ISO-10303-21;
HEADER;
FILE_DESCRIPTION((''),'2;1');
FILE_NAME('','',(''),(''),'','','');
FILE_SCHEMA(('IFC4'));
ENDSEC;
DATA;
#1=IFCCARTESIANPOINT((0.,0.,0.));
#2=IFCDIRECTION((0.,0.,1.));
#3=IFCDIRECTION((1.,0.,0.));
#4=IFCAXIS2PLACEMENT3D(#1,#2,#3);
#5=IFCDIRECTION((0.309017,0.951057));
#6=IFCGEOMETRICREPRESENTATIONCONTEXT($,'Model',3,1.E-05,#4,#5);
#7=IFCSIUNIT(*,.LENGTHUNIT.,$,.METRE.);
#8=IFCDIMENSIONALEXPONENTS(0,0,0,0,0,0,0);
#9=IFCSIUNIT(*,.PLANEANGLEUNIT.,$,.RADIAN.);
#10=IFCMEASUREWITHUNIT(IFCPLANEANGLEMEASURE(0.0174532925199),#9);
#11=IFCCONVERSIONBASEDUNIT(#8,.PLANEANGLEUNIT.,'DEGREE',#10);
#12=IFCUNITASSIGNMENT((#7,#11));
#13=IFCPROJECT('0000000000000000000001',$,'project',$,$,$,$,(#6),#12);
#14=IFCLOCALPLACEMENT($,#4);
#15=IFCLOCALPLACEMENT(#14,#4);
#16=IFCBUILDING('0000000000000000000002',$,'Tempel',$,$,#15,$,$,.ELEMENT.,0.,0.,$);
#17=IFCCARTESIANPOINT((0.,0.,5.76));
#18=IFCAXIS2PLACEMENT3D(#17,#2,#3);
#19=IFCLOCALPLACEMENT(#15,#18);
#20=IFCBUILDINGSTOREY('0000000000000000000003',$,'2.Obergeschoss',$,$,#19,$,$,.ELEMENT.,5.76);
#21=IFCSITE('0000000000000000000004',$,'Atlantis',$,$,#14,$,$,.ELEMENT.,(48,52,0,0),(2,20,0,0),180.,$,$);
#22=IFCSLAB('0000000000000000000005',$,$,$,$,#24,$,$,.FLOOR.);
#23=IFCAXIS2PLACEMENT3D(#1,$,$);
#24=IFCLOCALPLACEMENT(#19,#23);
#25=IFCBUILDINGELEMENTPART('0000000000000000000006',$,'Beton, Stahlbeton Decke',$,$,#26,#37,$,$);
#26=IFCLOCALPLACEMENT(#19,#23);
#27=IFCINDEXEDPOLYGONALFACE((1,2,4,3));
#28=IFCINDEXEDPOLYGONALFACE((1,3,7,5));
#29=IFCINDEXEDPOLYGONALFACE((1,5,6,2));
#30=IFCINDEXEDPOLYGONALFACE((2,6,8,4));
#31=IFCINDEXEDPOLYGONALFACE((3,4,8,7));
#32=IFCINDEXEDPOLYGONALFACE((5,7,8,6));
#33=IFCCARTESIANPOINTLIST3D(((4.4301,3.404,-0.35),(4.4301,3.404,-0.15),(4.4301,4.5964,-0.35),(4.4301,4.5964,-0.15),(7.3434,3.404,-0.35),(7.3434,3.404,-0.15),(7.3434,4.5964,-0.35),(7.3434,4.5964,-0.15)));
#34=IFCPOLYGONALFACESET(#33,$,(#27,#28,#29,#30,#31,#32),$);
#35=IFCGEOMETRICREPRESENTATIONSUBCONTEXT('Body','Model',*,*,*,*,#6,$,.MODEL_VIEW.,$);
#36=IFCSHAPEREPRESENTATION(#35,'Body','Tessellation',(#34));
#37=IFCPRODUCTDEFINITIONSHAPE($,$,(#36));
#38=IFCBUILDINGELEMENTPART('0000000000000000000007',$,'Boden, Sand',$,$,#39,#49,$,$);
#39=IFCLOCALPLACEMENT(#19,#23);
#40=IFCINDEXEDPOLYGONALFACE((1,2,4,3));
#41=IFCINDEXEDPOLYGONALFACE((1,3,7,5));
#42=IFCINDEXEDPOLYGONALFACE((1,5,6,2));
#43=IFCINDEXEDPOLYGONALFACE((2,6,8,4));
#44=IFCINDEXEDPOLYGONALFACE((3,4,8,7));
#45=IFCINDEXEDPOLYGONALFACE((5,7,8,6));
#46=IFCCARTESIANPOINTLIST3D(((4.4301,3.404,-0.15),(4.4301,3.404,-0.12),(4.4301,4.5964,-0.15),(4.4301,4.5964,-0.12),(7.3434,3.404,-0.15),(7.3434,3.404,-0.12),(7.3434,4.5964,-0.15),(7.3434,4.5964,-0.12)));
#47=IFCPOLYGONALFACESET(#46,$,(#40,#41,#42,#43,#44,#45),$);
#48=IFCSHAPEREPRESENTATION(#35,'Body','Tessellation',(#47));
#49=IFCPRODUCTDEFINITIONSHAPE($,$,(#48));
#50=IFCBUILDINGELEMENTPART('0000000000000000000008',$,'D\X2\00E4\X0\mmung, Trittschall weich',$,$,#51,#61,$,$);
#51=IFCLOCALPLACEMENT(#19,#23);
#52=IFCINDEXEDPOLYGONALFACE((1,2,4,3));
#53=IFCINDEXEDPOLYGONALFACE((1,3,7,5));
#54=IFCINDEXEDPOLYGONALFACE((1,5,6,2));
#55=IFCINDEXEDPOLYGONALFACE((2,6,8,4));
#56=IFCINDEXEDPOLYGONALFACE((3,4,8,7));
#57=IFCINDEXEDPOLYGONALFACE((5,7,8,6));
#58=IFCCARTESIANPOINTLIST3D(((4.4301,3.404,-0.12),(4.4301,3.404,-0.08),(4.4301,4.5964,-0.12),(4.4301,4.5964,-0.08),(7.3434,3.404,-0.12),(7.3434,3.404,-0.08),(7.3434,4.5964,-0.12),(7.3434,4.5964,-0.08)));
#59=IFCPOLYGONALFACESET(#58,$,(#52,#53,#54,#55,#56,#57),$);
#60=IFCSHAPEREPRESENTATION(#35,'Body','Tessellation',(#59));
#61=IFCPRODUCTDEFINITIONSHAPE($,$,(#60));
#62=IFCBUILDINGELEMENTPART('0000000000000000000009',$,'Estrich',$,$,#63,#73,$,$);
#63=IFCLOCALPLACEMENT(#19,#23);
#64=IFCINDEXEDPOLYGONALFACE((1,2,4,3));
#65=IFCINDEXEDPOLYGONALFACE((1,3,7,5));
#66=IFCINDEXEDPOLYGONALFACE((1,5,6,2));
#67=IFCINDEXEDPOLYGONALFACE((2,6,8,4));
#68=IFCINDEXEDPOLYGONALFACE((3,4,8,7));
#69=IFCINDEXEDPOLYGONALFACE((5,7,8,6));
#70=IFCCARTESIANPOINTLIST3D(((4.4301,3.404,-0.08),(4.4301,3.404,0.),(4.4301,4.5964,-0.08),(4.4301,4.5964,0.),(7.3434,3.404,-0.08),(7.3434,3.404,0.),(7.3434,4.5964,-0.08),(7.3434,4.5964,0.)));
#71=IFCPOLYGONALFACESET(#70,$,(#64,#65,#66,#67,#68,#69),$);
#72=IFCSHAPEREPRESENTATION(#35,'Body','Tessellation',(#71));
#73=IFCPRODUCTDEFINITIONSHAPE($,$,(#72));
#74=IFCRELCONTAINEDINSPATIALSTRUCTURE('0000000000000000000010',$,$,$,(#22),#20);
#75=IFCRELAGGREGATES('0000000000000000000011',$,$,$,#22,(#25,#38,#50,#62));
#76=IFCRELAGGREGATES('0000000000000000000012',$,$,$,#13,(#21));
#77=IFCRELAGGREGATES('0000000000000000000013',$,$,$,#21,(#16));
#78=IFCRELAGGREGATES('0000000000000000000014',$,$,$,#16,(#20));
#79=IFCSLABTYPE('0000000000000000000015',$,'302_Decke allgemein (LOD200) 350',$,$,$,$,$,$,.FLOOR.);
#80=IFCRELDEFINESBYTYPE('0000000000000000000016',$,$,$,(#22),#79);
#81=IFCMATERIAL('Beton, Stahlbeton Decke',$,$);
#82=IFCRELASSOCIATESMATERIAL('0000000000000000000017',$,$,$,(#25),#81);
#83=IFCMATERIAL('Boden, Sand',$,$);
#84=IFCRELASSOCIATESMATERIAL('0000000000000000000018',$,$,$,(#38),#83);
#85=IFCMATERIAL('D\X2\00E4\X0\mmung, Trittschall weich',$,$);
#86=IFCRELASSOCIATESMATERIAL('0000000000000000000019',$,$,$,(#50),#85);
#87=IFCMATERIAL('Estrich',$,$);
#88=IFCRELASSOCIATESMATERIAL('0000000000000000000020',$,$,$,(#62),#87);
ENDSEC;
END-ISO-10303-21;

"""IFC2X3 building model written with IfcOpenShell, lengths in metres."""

from ifc_helpers import new_model, entity, si_unit, converted_unit, direction, frame, origin_with_axes, place, context, subcontext, project, spatial, polyline, outline, extrude, material, type_object, element, aggregate, save


model = new_model("IFC2X3")

# Units and contexts
model_context = context("Model", 3, precision=1e-05, world=origin_with_axes(), true_north=direction((0.309017, 0.951057)))
body_context = subcontext(model_context, "Body", "Model", "MODEL_VIEW")
ifc_project = project(units=[si_unit("LENGTHUNIT", "METRE"), converted_unit("PLANEANGLEUNIT", "DEGREE", entity("IfcPlaneAngleMeasure", 0.0174532925199), si_unit("PLANEANGLEUNIT", "RADIAN"), dimensions=[0, 0, 0, 0, 0, 0, 0])], contexts=[model_context])

# Site, building, storey
site_placement = place(None, origin_with_axes())
site = spatial("IfcSite", under=ifc_project, at=site_placement, Name="Atlantis", CompositionType="ELEMENT", RefLatitude=(48, 52, 0, 0), RefLongitude=(2, 20, 0, 0), RefElevation=180.0)
building_placement = place(site_placement, origin_with_axes())
building = spatial("IfcBuilding", under=site, at=building_placement, Name="Tempel", CompositionType="ELEMENT", ElevationOfRefHeight=0.0, ElevationOfTerrain=0.0)
storey_placement = place(building_placement, frame((0.0, 0.0, 5.76), z_axis=(0.0, 0.0, 1.0), x_axis=(1.0, 0.0, 0.0)))
storey = spatial("IfcBuildingStorey", under=building, at=storey_placement, Name="2.Obergeschoss", CompositionType="ELEMENT", Elevation=5.76)

# Slab, building element parts
slab_type = type_object("IfcSlabType", Name="302_Decke allgemein (LOD200) 350", PredefinedType="FLOOR")
slab_placement = place(storey_placement, frame((4.4301, 3.404, -0.15), z_axis=(0.0, 0.0, 1.0), x_axis=(1.0, 0.0, 0.0)))
slab = element("IfcSlab", 1, at=slab_placement, inside=storey, type_object=slab_type, PredefinedType="FLOOR")
ifc_material_1 = material(Name="Beton, Stahlbeton Decke")
building_element_part_1_placement = place(slab_placement, origin_with_axes())
building_element_part_1 = element("IfcBuildingElementPart", 2, at=building_element_part_1_placement, material=ifc_material_1, Name="Beton, Stahlbeton Decke", context=body_context, shape_type="SweptSolid", body=[
    extrude(outline(polyline([(0.0, 0.0), (2.9133, 0.0), (2.9133, 1.1924), (0.0, 1.1924), (0.0, 0.0)])), frame((0.0, 0.0, -0.2), z_axis=(0.0, 0.0, 1.0), x_axis=(1.0, 0.0, 0.0)), (0.0, 0.0, 1.0), 0.2),
])
ifc_material_2 = material(Name="Boden, Sand")
building_element_part_2_placement = place(slab_placement, origin_with_axes())
building_element_part_2 = element("IfcBuildingElementPart", 3, at=building_element_part_2_placement, material=ifc_material_2, Name="Boden, Sand", context=body_context, shape_type="SweptSolid", body=[
    extrude(outline(polyline([(0.0, 0.0), (2.9133, 0.0), (2.9133, 1.1924), (0.0, 1.1924), (0.0, 0.0)])), origin_with_axes(), (0.0, 0.0, 1.0), 0.03),
])
ifc_material_3 = material(Name="Dämmung, Trittschall weich")
building_element_part_3_placement = place(slab_placement, origin_with_axes())
building_element_part_3 = element("IfcBuildingElementPart", 4, at=building_element_part_3_placement, material=ifc_material_3, Name="Dämmung, Trittschall weich", context=body_context, shape_type="SweptSolid", body=[
    extrude(outline(polyline([(0.0, 0.0), (2.9133, 0.0), (2.9133, 1.1924), (0.0, 1.1924), (0.0, 0.0)])), frame((0.0, 0.0, 0.03), z_axis=(0.0, 0.0, 1.0), x_axis=(1.0, 0.0, 0.0)), (0.0, 0.0, 1.0), 0.04),
])
ifc_material_4 = material(Name="Estrich")
building_element_part_4_placement = place(slab_placement, origin_with_axes())
building_element_part_4 = element("IfcBuildingElementPart", 5, at=building_element_part_4_placement, material=ifc_material_4, Name="Estrich", context=body_context, shape_type="SweptSolid", body=[
    extrude(outline(polyline([(0.0, 0.0), (2.9133, 0.0), (2.9133, 1.1924), (0.0, 1.1924), (0.0, 0.0)])), frame((0.0, 0.0, 0.07), z_axis=(0.0, 0.0, 1.0), x_axis=(1.0, 0.0, 0.0)), (0.0, 0.0, 1.0), 0.08),
])
aggregate(slab, [building_element_part_1, building_element_part_2, building_element_part_3, building_element_part_4])

save(model, "model.ifc")
